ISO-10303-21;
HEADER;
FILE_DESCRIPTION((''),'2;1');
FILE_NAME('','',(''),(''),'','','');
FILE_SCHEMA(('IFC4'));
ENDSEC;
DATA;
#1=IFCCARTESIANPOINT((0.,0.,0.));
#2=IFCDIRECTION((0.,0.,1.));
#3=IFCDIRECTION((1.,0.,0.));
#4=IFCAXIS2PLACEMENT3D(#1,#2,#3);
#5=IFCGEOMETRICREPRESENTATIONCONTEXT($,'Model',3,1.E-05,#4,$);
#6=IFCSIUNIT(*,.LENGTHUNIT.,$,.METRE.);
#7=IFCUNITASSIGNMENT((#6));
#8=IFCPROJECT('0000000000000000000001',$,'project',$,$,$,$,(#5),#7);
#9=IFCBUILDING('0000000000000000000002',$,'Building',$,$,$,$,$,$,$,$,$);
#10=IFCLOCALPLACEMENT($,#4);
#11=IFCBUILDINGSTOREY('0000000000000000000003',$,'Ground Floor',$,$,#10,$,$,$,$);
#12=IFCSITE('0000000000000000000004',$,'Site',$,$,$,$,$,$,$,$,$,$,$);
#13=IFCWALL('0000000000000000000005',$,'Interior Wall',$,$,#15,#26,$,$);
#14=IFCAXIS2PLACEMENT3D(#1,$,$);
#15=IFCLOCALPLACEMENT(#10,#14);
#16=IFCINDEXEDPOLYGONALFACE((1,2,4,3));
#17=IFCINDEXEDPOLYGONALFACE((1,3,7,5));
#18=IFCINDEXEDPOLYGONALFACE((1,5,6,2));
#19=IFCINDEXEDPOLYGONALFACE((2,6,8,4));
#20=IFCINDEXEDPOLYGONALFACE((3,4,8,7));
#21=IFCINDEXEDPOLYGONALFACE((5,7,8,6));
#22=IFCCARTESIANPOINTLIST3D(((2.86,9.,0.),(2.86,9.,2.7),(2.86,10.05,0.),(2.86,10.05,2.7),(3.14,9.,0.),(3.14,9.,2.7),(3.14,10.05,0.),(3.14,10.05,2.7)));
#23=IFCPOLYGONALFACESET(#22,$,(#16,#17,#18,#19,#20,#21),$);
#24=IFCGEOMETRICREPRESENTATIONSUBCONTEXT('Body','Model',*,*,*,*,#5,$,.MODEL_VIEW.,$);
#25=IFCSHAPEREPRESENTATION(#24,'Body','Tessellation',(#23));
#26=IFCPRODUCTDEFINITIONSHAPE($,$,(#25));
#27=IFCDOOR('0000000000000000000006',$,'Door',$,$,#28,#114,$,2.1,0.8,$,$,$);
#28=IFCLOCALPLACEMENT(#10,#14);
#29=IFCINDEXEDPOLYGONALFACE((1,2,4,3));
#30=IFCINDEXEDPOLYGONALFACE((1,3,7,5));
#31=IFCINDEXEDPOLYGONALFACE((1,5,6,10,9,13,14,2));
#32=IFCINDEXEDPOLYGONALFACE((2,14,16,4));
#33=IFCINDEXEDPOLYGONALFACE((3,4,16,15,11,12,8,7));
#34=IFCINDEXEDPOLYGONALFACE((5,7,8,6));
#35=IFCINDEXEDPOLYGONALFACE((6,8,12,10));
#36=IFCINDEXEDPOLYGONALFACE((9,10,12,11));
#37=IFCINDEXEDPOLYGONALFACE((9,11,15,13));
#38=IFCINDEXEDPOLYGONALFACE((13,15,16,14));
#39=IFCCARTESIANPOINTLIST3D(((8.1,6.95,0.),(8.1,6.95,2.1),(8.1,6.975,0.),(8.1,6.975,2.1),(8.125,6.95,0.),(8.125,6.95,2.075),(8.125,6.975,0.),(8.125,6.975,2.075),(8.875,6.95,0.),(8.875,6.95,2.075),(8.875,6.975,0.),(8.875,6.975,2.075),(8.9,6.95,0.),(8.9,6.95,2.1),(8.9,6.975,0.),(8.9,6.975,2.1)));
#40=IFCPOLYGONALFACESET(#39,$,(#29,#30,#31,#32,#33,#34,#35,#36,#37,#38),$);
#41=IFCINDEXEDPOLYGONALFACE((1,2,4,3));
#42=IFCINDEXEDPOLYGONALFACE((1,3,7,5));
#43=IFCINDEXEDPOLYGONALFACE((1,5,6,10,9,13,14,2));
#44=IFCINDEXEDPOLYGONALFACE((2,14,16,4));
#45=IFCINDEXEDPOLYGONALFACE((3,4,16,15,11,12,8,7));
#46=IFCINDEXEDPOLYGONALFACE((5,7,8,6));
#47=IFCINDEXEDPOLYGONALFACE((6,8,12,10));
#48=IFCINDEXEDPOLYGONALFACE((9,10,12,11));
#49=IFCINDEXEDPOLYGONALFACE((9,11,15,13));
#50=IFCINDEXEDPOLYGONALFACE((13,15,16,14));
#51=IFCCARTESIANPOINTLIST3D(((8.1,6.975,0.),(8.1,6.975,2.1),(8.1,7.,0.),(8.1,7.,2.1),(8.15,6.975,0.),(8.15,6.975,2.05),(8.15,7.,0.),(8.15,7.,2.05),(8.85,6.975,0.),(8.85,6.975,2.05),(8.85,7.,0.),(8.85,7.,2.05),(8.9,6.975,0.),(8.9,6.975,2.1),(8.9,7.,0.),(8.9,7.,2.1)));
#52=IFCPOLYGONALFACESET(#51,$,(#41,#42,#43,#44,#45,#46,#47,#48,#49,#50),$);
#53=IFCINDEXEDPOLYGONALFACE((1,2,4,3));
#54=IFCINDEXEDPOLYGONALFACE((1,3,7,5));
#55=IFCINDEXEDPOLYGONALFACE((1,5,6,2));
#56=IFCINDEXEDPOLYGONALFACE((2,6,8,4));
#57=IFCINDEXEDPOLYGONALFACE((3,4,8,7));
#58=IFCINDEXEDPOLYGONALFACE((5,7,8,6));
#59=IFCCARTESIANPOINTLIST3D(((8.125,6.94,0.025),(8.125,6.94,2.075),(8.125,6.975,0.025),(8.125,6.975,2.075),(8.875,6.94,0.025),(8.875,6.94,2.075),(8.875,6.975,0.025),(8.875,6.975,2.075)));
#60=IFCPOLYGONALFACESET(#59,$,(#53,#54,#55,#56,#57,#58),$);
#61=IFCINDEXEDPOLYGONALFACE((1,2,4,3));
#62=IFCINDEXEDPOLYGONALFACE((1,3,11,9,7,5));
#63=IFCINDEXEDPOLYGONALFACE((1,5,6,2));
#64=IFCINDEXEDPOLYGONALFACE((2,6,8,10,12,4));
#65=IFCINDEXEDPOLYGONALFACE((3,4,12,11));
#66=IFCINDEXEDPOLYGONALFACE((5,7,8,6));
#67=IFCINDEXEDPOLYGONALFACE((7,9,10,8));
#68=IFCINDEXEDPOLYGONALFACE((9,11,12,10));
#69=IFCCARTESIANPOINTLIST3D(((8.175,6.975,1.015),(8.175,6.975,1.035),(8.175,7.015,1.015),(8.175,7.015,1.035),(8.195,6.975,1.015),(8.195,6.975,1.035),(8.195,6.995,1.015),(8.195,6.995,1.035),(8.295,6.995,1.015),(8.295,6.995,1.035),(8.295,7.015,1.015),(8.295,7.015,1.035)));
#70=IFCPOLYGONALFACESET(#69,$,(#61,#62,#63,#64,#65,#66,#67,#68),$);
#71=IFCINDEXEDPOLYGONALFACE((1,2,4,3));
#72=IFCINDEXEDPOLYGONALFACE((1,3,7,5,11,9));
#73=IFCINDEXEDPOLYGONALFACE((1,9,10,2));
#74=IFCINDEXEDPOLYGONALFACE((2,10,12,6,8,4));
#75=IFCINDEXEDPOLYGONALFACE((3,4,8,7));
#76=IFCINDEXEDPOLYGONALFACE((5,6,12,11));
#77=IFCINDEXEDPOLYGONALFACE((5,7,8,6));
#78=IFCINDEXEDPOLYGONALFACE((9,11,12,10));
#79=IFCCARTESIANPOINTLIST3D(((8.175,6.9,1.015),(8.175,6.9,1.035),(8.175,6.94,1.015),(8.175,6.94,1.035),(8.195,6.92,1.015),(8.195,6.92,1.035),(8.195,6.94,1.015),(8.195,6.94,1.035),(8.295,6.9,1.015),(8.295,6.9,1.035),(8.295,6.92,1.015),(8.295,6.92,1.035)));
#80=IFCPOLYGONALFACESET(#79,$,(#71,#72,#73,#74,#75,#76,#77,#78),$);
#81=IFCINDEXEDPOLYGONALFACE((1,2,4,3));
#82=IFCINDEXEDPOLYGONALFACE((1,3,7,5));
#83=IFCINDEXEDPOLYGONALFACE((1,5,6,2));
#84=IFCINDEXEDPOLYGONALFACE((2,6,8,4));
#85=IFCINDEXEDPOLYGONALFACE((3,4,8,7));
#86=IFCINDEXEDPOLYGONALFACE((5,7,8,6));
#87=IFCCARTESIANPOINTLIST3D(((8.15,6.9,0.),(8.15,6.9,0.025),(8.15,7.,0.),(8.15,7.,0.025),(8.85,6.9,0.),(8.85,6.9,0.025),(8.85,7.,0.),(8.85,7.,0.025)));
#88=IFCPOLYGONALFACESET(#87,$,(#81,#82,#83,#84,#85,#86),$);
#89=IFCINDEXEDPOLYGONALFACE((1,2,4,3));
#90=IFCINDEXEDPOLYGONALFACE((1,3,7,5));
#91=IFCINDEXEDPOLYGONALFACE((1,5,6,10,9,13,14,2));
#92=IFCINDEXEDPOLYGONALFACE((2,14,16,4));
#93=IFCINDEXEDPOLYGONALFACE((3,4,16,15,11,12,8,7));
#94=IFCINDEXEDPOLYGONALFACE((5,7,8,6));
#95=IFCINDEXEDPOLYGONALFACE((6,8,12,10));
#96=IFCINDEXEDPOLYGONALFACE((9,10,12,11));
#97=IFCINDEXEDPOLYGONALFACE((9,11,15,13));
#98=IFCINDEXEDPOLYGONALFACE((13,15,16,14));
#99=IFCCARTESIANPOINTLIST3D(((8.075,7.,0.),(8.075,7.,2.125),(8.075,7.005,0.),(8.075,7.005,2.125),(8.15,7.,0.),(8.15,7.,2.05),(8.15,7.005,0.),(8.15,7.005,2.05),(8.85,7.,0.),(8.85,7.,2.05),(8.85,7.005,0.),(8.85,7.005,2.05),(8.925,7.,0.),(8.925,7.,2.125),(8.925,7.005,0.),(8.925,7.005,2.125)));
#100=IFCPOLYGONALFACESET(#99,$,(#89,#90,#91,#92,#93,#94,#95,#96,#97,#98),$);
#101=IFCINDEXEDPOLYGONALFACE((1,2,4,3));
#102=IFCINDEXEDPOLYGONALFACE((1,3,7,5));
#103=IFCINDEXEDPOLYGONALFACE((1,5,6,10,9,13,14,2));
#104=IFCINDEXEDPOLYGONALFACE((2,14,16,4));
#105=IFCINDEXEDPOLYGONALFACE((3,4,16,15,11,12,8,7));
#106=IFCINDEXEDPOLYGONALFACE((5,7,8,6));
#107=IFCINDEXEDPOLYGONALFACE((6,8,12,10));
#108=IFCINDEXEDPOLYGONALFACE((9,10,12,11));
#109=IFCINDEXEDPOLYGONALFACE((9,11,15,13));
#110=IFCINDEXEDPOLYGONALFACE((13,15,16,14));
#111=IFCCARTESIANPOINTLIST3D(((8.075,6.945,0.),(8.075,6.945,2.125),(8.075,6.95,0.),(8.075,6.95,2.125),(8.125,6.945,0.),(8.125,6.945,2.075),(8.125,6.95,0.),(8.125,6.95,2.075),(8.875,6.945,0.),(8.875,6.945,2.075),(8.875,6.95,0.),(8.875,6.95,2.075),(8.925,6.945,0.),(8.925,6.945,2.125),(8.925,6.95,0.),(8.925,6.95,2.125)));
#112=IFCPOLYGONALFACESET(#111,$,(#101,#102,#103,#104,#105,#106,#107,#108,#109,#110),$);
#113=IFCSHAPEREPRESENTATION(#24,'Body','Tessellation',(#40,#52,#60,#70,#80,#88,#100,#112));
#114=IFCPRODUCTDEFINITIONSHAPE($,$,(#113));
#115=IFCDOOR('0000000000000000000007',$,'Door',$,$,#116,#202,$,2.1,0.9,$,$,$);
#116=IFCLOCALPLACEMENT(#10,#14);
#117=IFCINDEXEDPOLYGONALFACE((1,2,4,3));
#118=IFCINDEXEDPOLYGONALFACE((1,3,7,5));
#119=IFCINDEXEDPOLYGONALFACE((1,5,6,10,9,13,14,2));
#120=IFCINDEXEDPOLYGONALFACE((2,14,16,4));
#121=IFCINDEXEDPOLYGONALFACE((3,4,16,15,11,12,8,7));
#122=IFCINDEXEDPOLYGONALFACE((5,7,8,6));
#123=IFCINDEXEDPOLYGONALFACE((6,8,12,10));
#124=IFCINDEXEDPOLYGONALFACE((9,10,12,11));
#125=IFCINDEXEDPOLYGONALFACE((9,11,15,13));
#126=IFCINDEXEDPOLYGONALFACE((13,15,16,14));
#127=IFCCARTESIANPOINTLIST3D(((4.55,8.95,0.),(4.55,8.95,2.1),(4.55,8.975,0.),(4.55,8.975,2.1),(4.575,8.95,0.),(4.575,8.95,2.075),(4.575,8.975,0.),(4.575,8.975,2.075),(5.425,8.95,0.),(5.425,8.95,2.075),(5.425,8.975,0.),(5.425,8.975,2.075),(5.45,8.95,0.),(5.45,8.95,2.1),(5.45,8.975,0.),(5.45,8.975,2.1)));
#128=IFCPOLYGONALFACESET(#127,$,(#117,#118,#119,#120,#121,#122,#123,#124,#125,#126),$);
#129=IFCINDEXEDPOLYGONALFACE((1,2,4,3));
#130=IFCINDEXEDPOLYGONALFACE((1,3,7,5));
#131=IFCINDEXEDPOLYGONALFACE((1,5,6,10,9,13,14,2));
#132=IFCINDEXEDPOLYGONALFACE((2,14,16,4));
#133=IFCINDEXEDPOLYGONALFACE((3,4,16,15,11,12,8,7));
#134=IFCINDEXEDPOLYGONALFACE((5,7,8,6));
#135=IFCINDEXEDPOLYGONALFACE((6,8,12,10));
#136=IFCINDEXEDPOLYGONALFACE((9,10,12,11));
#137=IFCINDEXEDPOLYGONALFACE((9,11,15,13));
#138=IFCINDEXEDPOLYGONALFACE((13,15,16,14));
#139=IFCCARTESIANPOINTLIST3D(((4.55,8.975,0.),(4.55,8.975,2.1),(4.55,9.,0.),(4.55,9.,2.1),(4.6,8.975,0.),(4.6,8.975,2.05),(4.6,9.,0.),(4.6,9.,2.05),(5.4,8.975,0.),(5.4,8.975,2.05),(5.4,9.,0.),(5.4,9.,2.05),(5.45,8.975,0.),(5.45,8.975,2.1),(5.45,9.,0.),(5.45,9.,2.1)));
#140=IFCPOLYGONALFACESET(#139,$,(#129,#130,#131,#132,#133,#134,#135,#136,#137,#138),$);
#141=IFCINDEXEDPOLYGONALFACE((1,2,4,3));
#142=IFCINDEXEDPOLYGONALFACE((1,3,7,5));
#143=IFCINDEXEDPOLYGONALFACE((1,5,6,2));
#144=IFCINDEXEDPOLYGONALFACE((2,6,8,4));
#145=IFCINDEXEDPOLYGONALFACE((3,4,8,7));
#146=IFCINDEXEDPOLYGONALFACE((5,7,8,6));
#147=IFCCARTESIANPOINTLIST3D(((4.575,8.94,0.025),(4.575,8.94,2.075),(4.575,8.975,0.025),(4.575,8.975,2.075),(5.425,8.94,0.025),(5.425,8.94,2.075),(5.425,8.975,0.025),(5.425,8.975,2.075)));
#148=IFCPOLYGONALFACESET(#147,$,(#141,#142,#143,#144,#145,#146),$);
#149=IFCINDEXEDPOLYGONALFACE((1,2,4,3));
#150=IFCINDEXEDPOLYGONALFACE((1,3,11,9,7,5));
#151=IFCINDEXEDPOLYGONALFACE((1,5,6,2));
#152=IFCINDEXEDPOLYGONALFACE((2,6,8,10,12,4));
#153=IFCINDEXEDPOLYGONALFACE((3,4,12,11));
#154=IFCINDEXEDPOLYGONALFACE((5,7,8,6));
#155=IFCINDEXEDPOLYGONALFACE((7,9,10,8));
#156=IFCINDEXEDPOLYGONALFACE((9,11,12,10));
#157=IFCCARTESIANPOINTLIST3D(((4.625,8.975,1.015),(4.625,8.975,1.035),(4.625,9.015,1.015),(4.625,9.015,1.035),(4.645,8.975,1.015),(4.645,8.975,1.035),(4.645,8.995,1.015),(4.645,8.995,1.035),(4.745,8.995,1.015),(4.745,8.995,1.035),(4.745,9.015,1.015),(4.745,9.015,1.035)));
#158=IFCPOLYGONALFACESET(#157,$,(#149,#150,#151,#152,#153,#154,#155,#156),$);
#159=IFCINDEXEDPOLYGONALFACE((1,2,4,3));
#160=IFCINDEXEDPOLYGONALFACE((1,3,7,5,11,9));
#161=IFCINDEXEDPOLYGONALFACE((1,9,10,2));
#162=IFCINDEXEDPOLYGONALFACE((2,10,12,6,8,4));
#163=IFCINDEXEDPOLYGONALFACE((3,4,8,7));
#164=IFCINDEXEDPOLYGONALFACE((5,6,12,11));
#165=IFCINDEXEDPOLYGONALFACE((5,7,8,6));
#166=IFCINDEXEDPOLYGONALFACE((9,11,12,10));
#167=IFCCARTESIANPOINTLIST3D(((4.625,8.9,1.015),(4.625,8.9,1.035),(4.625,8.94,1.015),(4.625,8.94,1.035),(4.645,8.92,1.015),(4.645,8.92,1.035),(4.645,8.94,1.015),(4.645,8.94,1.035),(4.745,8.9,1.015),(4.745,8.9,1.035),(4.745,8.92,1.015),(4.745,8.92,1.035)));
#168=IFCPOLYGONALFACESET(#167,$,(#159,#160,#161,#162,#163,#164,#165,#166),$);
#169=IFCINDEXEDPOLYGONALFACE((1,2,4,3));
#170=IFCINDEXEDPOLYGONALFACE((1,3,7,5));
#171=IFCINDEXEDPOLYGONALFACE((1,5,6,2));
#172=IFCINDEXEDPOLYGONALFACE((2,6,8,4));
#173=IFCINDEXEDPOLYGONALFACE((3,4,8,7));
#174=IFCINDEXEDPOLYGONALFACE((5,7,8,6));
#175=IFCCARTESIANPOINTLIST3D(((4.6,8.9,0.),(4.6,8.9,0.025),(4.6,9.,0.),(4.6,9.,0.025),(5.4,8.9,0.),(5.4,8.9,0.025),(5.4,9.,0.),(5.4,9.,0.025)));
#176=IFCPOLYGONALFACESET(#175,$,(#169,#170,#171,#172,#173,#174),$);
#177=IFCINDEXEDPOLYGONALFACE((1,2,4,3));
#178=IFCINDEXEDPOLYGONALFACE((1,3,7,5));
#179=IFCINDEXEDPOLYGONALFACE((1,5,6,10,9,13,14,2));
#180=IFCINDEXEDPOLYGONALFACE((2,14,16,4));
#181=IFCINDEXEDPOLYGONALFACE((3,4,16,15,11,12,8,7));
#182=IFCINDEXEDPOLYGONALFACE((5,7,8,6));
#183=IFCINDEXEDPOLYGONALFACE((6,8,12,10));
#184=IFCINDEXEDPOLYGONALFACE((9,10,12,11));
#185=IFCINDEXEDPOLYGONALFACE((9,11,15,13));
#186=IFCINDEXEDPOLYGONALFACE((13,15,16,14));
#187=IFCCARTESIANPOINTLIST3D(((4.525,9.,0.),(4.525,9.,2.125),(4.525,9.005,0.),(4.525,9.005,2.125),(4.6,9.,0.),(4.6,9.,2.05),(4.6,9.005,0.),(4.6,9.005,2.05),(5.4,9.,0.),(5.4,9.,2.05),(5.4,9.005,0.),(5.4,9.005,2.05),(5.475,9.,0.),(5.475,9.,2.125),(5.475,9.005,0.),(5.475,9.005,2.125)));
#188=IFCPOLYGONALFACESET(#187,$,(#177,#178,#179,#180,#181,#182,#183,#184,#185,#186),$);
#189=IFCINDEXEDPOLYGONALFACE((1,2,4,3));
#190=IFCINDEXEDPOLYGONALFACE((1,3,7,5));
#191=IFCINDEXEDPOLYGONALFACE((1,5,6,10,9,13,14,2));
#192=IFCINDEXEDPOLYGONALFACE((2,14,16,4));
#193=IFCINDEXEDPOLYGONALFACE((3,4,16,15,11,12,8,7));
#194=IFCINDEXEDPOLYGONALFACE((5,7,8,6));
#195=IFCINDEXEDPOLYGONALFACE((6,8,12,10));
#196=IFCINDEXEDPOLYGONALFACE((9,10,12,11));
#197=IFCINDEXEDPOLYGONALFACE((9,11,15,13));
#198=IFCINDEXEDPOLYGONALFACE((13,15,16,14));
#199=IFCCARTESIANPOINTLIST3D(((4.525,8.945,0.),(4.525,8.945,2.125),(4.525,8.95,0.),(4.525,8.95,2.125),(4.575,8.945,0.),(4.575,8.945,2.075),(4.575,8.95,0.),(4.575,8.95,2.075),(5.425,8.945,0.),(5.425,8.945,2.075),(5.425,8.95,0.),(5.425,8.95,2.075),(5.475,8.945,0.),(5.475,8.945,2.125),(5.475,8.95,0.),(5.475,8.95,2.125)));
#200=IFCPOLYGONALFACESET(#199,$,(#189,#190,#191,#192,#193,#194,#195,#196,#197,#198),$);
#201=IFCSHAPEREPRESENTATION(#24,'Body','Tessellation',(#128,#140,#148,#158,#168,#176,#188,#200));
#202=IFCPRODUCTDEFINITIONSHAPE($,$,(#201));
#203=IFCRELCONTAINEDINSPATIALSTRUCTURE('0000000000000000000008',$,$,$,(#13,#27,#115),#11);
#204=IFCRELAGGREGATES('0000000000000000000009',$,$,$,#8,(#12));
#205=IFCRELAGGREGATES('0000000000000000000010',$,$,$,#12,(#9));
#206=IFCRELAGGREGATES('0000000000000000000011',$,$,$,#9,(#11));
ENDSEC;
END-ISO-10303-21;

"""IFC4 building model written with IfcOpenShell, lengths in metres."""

from ifc_helpers import new_model, si_unit, frame, origin_with_axes, place, context, subcontext, project, spatial, line, indexed_curve, outline, extrude, element, save


model = new_model("IFC4")

# Units and contexts
model_context = context("Model", 3, precision=1e-05, world=origin_with_axes())
body_context = subcontext(model_context, "Body", "Model", "MODEL_VIEW")
ifc_project = project(units=[si_unit("LENGTHUNIT", "METRE")], contexts=[model_context])

# Site, building, storey
site = spatial("IfcSite", under=ifc_project, Name="Site")
building = spatial("IfcBuilding", under=site, Name="Building")
storey_placement = place(None, origin_with_axes())
storey = spatial("IfcBuildingStorey", under=building, at=storey_placement, Name="Ground Floor")

# Wall
for number, where, z_axis, x_axis, name in (
    (1, (3.0, 10.05, 0.0), (0.0, 0.0, 1.0), (0.0, -1.0, 0.0), "Interior Wall"),
):
    element("IfcWall", number, at=place(storey_placement, frame(where, z_axis=z_axis, x_axis=x_axis)), inside=storey, Name=name, context=body_context, shape_type="SweptSolid", body=[
        extrude(outline(indexed_curve([(0.0, 0.0), (0.0, 0.28), (1.05, 0.28), (1.05, 0.0), (0.0, 0.0)], self_intersect=False)), frame((0.0, -0.14, 0.0), z_axis=(0.0, 0.0, 1.0), x_axis=(1.0, 0.0, 0.0)), (0.0, 0.0, 1.0), 2.7),
    ])

# Doors
door_1_placement = place(storey_placement, frame((8.9, 7.0, 0.0), z_axis=(0.0, 0.0, 1.0), x_axis=(-1.0, 0.0, 0.0)))
element("IfcDoor", 2, at=door_1_placement, inside=storey, Name="Door", OverallHeight=2.1, OverallWidth=0.8, context=body_context, shape_type="SweptSolid", body=[
    extrude(outline(indexed_curve([(0.0, 0.0), (0.0, 2.1), (0.8, 2.1), (0.8, 0.0), (0.775, 0.0), (0.775, 2.075), (0.025, 2.075), (0.025, 0.0)], segments=[line(1, 2, 3, 4, 5, 6, 7, 8, 1)])), frame((0.0, 0.025, 0.0), z_axis=(0.0, -1.0, 0.0), x_axis=(1.0, 0.0, 0.0)), (0.0, 0.0, -1.0), 0.025),
    extrude(outline(indexed_curve([(0.0, 0.0), (0.0, 2.1), (0.8, 2.1), (0.8, 0.0), (0.75, 0.0), (0.75, 2.05), (0.05, 2.05), (0.05, 0.0)], segments=[line(1, 2, 3, 4, 5, 6, 7, 8, 1)])), frame((0.0, 0.0, 0.0), z_axis=(0.0, -1.0, 0.0), x_axis=(1.0, 0.0, 0.0)), (0.0, 0.0, -1.0), 0.025),
    extrude(outline(indexed_curve([(0.0, 0.0), (0.75, 0.0), (0.75, 0.035), (0.0, 0.035)], segments=[line(1, 2, 3, 4, 1)])), frame((0.025, 0.025, 0.025), z_axis=(0.0, 0.0, 1.0), x_axis=(1.0, 0.0, 0.0)), (0.0, 0.0, 1.0), 2.05),
    extrude(outline(indexed_curve([(0.0, 0.0), (0.0, -0.04), (-0.12, -0.04), (-0.12, -0.02), (-0.02, -0.02), (-0.02, 0.0)], segments=[line(1, 2, 3, 4, 5, 6, 1)])), frame((0.725, 0.025, 1.015), z_axis=(0.0, 0.0, 1.0), x_axis=(1.0, 0.0, 0.0)), (0.0, 0.0, 1.0), 0.02),
    extrude(outline(indexed_curve([(0.0, 0.0), (0.0, 0.04), (-0.12, 0.04), (-0.12, 0.02), (-0.02, 0.02), (-0.02, 0.0)], segments=[line(1, 2, 3, 4, 5, 6, 1)])), frame((0.725, 0.06, 1.015), z_axis=(0.0, 0.0, 1.0), x_axis=(1.0, 0.0, 0.0)), (0.0, 0.0, 1.0), 0.02),
    extrude(outline(indexed_curve([(0.0, 0.0), (0.7, 0.0), (0.7, 0.1), (0.0, 0.1)], segments=[line(1, 2, 3, 4, 1)])), frame((0.05, 0.0, 0.0), z_axis=(0.0, 0.0, 1.0), x_axis=(1.0, 0.0, 0.0)), (0.0, 0.0, 1.0), 0.025),
    extrude(outline(indexed_curve([(0.0, 0.0), (0.0, 2.125), (0.85, 2.125), (0.85, 0.0), (0.775, 0.0), (0.775, 2.05), (0.075, 2.05), (0.075, 0.0)], segments=[line(1, 2, 3, 4, 5, 6, 7, 8, 1)])), frame((-0.025, -0.005, 0.0), z_axis=(0.0, -1.0, 0.0), x_axis=(1.0, 0.0, 0.0)), (0.0, 0.0, -1.0), 0.005),
    extrude(outline(indexed_curve([(0.0, 0.0), (0.0, 2.125), (0.85, 2.125), (0.85, 0.0), (0.8, 0.0), (0.8, 2.075), (0.05, 2.075), (0.05, 0.0)], segments=[line(1, 2, 3, 4, 5, 6, 7, 8, 1)])), frame((-0.025, 0.05, 0.0), z_axis=(0.0, -1.0, 0.0), x_axis=(1.0, 0.0, 0.0)), (0.0, 0.0, -1.0), 0.005),
])
door_2_placement = place(storey_placement, frame((5.45, 9.0, 0.0), z_axis=(0.0, 0.0, 1.0), x_axis=(-1.0, 0.0, 0.0)))
element("IfcDoor", 3, at=door_2_placement, inside=storey, Name="Door", OverallHeight=2.1, OverallWidth=0.9, context=body_context, shape_type="SweptSolid", body=[
    extrude(outline(indexed_curve([(0.0, 0.0), (0.0, 2.1), (0.9, 2.1), (0.9, 0.0), (0.875, 0.0), (0.875, 2.075), (0.025, 2.075), (0.025, 0.0)], segments=[line(1, 2, 3, 4, 5, 6, 7, 8, 1)])), frame((0.0, 0.025, 0.0), z_axis=(0.0, -1.0, 0.0), x_axis=(1.0, 0.0, 0.0)), (0.0, 0.0, -1.0), 0.025),
    extrude(outline(indexed_curve([(0.0, 0.0), (0.0, 2.1), (0.9, 2.1), (0.9, 0.0), (0.85, 0.0), (0.85, 2.05), (0.05, 2.05), (0.05, 0.0)], segments=[line(1, 2, 3, 4, 5, 6, 7, 8, 1)])), frame((0.0, 0.0, 0.0), z_axis=(0.0, -1.0, 0.0), x_axis=(1.0, 0.0, 0.0)), (0.0, 0.0, -1.0), 0.025),
    extrude(outline(indexed_curve([(0.0, 0.0), (0.85, 0.0), (0.85, 0.035), (0.0, 0.035)], segments=[line(1, 2, 3, 4, 1)])), frame((0.025, 0.025, 0.025), z_axis=(0.0, 0.0, 1.0), x_axis=(1.0, 0.0, 0.0)), (0.0, 0.0, 1.0), 2.05),
    extrude(outline(indexed_curve([(0.0, 0.0), (0.0, -0.04), (-0.12, -0.04), (-0.12, -0.02), (-0.02, -0.02), (-0.02, 0.0)], segments=[line(1, 2, 3, 4, 5, 6, 1)])), frame((0.825, 0.025, 1.015), z_axis=(0.0, 0.0, 1.0), x_axis=(1.0, 0.0, 0.0)), (0.0, 0.0, 1.0), 0.02),
    extrude(outline(indexed_curve([(0.0, 0.0), (0.0, 0.04), (-0.12, 0.04), (-0.12, 0.02), (-0.02, 0.02), (-0.02, 0.0)], segments=[line(1, 2, 3, 4, 5, 6, 1)])), frame((0.825, 0.06, 1.015), z_axis=(0.0, 0.0, 1.0), x_axis=(1.0, 0.0, 0.0)), (0.0, 0.0, 1.0), 0.02),
    extrude(outline(indexed_curve([(0.0, 0.0), (0.8, 0.0), (0.8, 0.1), (0.0, 0.1)], segments=[line(1, 2, 3, 4, 1)])), frame((0.05, 0.0, 0.0), z_axis=(0.0, 0.0, 1.0), x_axis=(1.0, 0.0, 0.0)), (0.0, 0.0, 1.0), 0.025),
    extrude(outline(indexed_curve([(0.0, 0.0), (0.0, 2.125), (0.95, 2.125), (0.95, 0.0), (0.875, 0.0), (0.875, 2.05), (0.075, 2.05), (0.075, 0.0)], segments=[line(1, 2, 3, 4, 5, 6, 7, 8, 1)])), frame((-0.025, -0.005, 0.0), z_axis=(0.0, -1.0, 0.0), x_axis=(1.0, 0.0, 0.0)), (0.0, 0.0, -1.0), 0.005),
    extrude(outline(indexed_curve([(0.0, 0.0), (0.0, 2.125), (0.95, 2.125), (0.95, 0.0), (0.9, 0.0), (0.9, 2.075), (0.05, 2.075), (0.05, 0.0)], segments=[line(1, 2, 3, 4, 5, 6, 7, 8, 1)])), frame((-0.025, 0.05, 0.0), z_axis=(0.0, -1.0, 0.0), x_axis=(1.0, 0.0, 0.0)), (0.0, 0.0, -1.0), 0.005),
])

save(model, "model.ifc")
